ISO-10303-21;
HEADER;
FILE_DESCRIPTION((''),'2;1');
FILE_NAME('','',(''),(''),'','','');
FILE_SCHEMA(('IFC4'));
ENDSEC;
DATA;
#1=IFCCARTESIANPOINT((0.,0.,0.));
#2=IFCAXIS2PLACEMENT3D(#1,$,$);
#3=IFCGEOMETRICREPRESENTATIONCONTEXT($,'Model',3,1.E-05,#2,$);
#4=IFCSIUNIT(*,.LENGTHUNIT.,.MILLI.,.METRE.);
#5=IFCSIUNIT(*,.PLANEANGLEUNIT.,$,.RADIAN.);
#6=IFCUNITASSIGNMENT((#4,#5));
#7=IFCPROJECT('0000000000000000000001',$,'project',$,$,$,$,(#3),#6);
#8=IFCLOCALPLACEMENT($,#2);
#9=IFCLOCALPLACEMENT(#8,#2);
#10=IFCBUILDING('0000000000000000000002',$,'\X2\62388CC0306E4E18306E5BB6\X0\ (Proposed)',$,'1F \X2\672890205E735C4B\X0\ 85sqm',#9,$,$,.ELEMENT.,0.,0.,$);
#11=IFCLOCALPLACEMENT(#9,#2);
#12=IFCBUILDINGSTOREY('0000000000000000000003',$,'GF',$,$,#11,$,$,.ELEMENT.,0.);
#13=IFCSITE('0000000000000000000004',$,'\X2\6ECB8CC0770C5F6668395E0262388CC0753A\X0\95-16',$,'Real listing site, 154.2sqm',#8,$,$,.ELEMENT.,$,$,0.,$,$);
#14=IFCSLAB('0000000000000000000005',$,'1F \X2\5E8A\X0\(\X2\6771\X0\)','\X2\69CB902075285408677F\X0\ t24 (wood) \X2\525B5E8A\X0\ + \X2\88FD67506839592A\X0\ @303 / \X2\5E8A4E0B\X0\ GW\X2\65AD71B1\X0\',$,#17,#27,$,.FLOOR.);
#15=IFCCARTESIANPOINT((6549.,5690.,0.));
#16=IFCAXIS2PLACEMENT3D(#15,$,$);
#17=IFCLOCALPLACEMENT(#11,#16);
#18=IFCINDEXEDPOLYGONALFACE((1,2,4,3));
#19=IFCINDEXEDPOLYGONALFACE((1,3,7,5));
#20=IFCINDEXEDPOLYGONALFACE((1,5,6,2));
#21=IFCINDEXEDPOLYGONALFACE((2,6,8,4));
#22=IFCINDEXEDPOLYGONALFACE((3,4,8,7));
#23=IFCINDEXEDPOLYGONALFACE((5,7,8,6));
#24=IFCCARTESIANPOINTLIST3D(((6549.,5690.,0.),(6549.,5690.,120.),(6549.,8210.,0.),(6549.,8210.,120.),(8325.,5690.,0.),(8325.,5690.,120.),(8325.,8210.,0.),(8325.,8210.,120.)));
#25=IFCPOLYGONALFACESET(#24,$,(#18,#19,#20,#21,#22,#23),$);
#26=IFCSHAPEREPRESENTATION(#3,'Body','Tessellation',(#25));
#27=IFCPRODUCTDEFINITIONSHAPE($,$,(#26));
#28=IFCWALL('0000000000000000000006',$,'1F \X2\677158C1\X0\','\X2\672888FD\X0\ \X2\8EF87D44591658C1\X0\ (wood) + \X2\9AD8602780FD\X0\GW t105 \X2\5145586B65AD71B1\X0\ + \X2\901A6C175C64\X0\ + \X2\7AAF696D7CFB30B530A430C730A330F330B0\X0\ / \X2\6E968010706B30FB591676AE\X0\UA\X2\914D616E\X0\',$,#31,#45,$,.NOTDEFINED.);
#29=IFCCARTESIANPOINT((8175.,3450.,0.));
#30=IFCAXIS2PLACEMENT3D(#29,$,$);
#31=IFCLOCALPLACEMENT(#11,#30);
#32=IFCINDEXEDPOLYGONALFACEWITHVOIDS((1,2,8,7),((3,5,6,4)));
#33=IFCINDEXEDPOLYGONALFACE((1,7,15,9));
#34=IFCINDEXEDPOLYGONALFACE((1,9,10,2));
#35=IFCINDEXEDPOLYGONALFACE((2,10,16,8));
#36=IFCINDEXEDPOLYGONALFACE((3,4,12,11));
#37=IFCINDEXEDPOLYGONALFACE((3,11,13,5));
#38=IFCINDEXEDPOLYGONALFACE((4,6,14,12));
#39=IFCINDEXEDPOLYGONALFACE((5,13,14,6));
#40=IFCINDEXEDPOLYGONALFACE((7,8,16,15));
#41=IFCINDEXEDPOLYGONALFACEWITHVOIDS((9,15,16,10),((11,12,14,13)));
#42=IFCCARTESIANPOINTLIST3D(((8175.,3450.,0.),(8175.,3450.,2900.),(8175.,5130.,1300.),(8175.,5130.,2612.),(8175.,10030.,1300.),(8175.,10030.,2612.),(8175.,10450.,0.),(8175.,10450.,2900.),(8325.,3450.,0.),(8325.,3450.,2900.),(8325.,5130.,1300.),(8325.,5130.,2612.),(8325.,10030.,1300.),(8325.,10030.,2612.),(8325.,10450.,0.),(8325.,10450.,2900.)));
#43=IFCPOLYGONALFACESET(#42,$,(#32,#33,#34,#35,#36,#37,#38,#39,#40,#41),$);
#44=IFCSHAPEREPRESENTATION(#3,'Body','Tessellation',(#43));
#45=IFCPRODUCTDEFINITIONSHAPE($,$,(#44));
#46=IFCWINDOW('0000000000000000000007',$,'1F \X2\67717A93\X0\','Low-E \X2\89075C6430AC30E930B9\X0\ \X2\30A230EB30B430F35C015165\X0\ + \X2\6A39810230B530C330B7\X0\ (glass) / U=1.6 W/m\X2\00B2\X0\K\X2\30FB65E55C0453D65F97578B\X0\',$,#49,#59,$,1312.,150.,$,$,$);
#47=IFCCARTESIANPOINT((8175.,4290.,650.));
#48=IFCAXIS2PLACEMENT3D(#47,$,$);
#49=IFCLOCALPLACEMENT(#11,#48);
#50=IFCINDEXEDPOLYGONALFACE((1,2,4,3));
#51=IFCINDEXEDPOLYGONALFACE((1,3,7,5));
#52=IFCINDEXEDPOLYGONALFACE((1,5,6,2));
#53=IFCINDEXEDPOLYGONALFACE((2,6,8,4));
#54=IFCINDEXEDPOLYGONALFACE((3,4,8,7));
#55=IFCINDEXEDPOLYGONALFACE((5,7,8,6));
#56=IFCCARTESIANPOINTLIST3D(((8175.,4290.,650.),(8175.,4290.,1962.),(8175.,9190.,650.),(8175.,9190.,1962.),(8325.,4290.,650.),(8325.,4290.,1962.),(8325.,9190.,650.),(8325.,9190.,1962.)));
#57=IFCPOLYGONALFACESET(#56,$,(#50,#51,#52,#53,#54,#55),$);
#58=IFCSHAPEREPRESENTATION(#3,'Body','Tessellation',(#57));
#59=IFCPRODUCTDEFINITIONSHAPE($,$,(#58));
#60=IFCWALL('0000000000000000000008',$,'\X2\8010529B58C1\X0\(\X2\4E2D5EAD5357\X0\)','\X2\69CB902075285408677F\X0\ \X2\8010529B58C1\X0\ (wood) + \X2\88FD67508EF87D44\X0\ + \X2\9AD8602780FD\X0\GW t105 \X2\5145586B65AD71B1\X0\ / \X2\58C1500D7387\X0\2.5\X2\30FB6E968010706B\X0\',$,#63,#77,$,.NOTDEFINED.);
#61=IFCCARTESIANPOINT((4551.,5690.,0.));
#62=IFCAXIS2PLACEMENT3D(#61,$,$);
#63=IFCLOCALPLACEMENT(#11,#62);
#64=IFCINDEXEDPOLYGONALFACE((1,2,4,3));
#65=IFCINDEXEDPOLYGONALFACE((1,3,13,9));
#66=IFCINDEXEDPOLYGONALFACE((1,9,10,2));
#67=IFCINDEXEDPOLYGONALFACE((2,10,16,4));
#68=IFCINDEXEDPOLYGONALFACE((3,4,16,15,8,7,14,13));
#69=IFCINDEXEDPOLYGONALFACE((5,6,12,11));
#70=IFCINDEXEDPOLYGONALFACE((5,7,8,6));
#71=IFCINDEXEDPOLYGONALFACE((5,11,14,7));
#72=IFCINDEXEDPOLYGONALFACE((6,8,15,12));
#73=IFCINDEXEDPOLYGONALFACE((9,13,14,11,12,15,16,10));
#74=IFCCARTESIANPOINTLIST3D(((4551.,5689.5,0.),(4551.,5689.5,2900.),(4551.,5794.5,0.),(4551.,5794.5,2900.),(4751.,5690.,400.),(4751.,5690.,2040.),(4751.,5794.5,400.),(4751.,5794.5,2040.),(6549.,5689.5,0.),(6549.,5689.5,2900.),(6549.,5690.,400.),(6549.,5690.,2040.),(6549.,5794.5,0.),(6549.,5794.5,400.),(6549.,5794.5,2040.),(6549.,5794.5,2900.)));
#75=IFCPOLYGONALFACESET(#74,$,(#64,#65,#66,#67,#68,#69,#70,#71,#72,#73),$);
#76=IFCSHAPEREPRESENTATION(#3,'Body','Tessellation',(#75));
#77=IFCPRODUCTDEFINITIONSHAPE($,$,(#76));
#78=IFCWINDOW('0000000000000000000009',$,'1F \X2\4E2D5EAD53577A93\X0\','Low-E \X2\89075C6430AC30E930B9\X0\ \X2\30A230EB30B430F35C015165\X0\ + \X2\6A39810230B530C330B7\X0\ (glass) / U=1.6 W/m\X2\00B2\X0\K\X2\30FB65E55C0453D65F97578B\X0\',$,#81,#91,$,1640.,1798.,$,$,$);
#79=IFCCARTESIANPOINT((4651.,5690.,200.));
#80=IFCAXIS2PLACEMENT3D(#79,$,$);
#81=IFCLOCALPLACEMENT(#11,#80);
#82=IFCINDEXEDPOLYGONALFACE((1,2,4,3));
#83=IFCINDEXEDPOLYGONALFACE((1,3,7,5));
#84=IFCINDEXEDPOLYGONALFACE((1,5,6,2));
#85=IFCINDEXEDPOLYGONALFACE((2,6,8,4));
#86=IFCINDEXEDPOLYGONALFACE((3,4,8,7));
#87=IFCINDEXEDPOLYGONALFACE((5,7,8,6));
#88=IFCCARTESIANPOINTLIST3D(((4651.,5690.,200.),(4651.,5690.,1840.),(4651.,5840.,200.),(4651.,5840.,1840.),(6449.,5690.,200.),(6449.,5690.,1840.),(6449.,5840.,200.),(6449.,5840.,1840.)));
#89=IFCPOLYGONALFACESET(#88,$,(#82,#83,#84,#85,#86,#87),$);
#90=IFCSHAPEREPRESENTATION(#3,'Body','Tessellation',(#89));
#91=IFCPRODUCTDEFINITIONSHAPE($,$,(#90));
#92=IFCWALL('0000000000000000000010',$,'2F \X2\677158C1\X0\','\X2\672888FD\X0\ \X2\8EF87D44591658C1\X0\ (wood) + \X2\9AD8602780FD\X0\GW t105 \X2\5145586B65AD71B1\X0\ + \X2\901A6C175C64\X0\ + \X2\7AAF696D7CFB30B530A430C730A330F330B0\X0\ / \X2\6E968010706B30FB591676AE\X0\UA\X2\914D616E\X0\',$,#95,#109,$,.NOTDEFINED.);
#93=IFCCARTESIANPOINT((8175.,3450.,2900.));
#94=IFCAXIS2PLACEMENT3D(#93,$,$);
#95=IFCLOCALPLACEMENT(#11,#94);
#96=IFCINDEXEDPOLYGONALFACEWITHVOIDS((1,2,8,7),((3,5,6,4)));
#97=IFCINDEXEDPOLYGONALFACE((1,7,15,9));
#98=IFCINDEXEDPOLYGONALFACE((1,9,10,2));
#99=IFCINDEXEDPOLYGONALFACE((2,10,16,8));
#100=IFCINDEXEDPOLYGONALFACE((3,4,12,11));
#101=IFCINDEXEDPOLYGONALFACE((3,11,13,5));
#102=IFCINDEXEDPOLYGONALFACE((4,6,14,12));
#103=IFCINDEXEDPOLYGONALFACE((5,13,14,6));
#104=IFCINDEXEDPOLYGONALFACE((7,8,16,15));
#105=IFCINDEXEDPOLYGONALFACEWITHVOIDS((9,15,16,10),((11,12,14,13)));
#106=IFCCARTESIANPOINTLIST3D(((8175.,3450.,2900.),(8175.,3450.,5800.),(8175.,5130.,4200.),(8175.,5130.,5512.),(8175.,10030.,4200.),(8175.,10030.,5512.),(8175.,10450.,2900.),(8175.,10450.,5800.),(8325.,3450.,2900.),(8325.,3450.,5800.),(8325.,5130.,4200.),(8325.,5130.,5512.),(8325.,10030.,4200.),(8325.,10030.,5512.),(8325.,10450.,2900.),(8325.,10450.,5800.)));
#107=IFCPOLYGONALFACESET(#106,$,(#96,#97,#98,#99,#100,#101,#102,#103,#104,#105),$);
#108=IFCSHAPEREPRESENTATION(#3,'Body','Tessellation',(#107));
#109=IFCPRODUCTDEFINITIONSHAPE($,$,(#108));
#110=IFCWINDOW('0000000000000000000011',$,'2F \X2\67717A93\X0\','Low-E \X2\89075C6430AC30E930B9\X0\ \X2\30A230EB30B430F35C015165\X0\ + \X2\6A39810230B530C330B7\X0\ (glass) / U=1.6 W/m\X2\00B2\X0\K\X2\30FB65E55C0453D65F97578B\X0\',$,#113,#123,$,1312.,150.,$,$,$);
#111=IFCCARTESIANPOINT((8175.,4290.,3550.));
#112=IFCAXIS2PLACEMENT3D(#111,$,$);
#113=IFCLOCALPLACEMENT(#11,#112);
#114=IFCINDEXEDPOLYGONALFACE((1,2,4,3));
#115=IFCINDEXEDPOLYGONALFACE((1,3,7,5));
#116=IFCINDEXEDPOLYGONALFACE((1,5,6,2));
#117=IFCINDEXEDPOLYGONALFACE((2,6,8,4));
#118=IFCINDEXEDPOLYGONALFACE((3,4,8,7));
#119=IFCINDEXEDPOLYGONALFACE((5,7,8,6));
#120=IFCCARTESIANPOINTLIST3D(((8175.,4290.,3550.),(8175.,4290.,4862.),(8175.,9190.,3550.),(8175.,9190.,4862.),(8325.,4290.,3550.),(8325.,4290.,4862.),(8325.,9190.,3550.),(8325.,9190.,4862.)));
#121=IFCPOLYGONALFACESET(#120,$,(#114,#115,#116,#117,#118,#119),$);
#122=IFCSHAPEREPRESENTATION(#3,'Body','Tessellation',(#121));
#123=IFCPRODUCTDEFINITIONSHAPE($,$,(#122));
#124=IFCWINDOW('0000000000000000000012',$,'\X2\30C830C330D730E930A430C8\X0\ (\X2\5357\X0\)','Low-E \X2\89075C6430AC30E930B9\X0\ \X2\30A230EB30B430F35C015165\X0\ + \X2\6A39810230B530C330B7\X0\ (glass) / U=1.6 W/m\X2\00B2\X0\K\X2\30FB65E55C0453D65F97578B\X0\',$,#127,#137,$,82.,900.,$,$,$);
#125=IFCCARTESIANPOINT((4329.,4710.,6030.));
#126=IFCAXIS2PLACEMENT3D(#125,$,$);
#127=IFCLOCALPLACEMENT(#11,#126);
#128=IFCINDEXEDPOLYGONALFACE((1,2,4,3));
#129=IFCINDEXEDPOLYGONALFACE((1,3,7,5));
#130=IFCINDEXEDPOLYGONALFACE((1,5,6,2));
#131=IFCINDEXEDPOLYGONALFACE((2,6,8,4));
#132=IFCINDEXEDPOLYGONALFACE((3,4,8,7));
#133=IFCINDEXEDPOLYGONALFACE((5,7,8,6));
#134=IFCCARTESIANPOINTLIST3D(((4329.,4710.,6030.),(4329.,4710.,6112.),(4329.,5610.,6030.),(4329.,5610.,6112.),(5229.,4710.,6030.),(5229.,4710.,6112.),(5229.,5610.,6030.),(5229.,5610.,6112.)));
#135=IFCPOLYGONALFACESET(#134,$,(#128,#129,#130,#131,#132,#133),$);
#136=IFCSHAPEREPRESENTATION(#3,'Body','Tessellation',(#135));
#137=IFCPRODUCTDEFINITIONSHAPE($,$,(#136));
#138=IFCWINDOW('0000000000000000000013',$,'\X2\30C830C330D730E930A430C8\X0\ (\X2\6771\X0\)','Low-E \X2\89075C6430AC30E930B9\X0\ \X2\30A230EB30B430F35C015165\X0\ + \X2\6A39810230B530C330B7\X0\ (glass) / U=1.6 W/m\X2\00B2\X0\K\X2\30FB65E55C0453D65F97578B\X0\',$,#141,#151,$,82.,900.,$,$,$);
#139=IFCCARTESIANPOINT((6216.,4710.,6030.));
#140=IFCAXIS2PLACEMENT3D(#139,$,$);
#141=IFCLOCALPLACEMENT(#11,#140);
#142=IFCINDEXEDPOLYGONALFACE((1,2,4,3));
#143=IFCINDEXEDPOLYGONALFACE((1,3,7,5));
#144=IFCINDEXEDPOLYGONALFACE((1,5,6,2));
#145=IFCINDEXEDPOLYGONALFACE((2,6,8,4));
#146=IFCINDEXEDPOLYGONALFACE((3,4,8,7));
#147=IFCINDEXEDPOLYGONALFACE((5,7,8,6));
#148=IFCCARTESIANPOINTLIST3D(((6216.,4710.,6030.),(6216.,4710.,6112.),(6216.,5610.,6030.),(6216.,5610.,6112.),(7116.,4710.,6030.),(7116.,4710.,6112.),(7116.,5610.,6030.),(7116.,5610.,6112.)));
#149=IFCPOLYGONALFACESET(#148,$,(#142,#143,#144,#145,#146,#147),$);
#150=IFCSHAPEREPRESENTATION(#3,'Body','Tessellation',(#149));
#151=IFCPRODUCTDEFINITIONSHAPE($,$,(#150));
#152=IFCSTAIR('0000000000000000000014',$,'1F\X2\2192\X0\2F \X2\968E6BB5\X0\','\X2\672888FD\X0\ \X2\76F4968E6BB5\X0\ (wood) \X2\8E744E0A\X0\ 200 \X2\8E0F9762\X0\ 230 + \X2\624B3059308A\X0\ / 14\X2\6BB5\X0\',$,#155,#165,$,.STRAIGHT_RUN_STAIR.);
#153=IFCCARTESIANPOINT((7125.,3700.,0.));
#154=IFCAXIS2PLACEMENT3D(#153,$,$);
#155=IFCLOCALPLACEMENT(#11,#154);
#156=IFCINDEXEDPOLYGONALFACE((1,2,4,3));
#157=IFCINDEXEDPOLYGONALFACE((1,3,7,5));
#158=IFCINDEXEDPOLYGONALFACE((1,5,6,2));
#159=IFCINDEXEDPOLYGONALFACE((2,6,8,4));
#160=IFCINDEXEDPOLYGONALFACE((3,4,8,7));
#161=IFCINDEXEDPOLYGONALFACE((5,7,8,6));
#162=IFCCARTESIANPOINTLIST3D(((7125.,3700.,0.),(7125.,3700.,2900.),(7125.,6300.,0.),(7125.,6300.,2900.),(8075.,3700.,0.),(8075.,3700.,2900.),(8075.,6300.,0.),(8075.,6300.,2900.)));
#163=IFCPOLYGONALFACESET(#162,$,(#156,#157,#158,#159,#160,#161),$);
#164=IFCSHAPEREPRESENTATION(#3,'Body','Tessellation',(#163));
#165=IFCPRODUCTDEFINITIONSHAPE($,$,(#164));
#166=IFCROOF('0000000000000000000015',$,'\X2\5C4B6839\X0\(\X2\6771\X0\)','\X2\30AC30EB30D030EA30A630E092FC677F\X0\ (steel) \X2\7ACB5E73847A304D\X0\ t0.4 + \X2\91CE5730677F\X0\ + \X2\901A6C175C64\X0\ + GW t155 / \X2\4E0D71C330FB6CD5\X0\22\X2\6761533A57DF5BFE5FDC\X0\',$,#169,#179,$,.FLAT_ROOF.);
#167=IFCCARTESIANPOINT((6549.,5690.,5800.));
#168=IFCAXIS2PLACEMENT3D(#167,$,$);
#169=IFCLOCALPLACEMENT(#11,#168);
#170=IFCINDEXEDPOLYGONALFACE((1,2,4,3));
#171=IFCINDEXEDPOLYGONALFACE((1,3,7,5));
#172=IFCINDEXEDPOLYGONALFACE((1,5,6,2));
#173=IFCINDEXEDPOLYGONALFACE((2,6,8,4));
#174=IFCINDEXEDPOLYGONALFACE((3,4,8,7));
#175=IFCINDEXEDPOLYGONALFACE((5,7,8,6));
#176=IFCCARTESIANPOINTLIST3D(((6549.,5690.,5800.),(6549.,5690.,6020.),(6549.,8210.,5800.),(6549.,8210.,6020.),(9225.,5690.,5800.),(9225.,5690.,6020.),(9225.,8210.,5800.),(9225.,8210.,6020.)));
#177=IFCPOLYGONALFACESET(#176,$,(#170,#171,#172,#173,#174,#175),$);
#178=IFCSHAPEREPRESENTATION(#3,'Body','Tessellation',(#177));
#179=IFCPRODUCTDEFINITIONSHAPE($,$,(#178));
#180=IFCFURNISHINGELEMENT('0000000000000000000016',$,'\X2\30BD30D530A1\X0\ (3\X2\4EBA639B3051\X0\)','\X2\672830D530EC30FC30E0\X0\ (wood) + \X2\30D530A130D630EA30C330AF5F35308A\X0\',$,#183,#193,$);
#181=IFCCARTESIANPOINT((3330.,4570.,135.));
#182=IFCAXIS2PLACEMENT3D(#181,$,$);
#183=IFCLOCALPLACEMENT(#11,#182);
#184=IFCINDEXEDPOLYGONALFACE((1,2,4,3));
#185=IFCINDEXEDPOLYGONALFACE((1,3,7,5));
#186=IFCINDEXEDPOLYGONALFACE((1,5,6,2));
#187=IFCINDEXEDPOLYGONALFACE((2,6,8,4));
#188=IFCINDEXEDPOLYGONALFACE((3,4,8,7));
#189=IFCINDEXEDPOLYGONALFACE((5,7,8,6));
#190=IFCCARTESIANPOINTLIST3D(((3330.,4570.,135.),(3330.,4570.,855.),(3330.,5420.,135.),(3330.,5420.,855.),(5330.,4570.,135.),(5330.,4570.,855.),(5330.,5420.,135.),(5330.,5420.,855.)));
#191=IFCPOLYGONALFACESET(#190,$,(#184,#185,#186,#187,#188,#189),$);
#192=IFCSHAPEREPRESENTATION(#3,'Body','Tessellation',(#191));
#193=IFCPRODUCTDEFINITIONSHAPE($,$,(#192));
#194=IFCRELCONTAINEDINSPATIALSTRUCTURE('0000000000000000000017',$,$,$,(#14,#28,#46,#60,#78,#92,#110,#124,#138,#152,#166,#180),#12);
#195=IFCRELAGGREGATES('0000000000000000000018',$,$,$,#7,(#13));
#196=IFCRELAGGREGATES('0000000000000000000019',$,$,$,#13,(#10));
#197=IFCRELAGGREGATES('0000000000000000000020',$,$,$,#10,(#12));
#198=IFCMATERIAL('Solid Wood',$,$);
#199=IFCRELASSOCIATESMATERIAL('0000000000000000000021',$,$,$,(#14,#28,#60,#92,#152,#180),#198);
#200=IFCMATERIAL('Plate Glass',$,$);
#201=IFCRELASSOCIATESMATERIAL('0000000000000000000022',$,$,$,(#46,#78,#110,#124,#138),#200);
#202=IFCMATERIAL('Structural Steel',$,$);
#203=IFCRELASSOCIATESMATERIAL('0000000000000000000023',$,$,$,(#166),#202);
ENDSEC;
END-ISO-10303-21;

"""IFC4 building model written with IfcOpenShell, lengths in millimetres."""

from ifc_helpers import new_model, si_unit, frame, frame_2d, origin, place, context, project, spatial, rectangle, extrude, material, element, fill, save


model = new_model("IFC4")

# Units and contexts
model_context = context("Model", 3, precision=1e-05, world=origin())
ifc_project = project(units=[si_unit("LENGTHUNIT", "METRE", prefix="MILLI"), si_unit("PLANEANGLEUNIT", "RADIAN")], contexts=[model_context])

# Site, building, storey
site_placement = place(None, origin())
site = spatial("IfcSite", under=ifc_project, at=site_placement, Name="滋賀県彦根市戸賀町95-16", ObjectType="Real listing site, 154.2sqm", CompositionType="ELEMENT", RefElevation=0.0)
building_placement = place(site_placement, origin())
building = spatial("IfcBuilding", under=site, at=building_placement, Name="戸賀の丘の家 (Proposed)", ObjectType="1F 木造平屋 85sqm", CompositionType="ELEMENT", ElevationOfRefHeight=0.0, ElevationOfTerrain=0.0)
storey_placement = place(building_placement, origin())
storey = spatial("IfcBuildingStorey", under=building, at=storey_placement, Name="GF", CompositionType="ELEMENT", Elevation=0.0)

# Slab
ifc_material_1 = material(Name="Solid Wood")
slab_placement = place(storey_placement, frame((6549.0, 5690.0, 0.0)))
element("IfcSlab", 1, at=slab_placement, inside=storey, material=ifc_material_1, Name="1F 床(東)", Description="構造用合板 t24 (wood) 剛床 + 製材根太 @303 / 床下 GW断熱", PredefinedType="FLOOR", context=model_context, shape_type="SweptSolid", body=[
    extrude(rectangle(XDim=1776.0, YDim=2520.0, at=frame_2d((888.0, 1260.0))), frame((6549.0, 5690.0, 0.0)), (0.0, 0.0, 1.0), 120.0),
])

# Walls, openings, windows
wall_1_placement = place(storey_placement, frame((8175.0, 3450.0, 0.0)))
wall_1 = element("IfcWall", 2, at=wall_1_placement, inside=storey, material=ifc_material_1, Name="1F 東壁", Description="木製 軸組外壁 (wood) + 高性能GW t105 充填断熱 + 通気層 + 窯業系サイディング / 準耐火・外皮UA配慮", PredefinedType="NOTDEFINED", context=model_context, shape_type="SweptSolid", body=[
    extrude(rectangle(XDim=150.0, YDim=7000.0, at=frame_2d((75.0, 3500.0))), frame((8175.0, 3450.0, 0.0)), (0.0, 0.0, 1.0), 2900.0),
])
opening_1_placement = place(storey_placement, frame((8175.0, 4290.0, 650.0)))
opening_1 = element("IfcOpeningElement", 3, at=opening_1_placement, cuts=wall_1, PredefinedType="NOTDEFINED", context=model_context, shape_type="SweptSolid", body=[
    extrude(rectangle(XDim=150.0, YDim=4900.0, at=frame_2d((75.0, 2450.0))), frame((8175.0, 4290.0, 650.0)), (0.0, 0.0, 1.0), 1312.0),
])
ifc_material_2 = material(Name="Plate Glass")
window_1_placement = place(storey_placement, frame((8175.0, 4290.0, 650.0)))
window_1 = element("IfcWindow", 4, at=window_1_placement, inside=storey, material=ifc_material_2, Name="1F 東窓", Description="Low-E 複層ガラス アルゴン封入 + 樹脂サッシ (glass) / U=1.6 W/m²K・日射取得型", OverallHeight=1312.0, OverallWidth=150.0, context=model_context, shape_type="SweptSolid", body=[
    extrude(rectangle(XDim=150.0, YDim=4900.0, at=frame_2d((75.0, 2450.0))), frame((8175.0, 4290.0, 650.0)), (0.0, 0.0, 1.0), 1312.0),
])
fill(opening_1, window_1)
wall_2_placement = place(storey_placement, frame((4551.0, 5690.0, 0.0)))
wall_2 = element("IfcWall", 5, at=wall_2_placement, inside=storey, material=ifc_material_1, Name="耐力壁(中庭南)", Description="構造用合板 耐力壁 (wood) + 製材軸組 + 高性能GW t105 充填断熱 / 壁倍率2.5・準耐火", PredefinedType="NOTDEFINED", context=model_context, shape_type="SweptSolid", body=[
    extrude(rectangle(XDim=1998.0, YDim=105.0, at=frame_2d((999.0, 52.0))), frame((4551.0, 5690.0, 0.0)), (0.0, 0.0, 1.0), 2900.0),
])
opening_2_placement = place(storey_placement, frame((4651.0, 5690.0, 200.0)))
opening_2 = element("IfcOpeningElement", 6, at=opening_2_placement, cuts=wall_2, PredefinedType="NOTDEFINED", context=model_context, shape_type="SweptSolid", body=[
    extrude(rectangle(XDim=1798.0, YDim=150.0, at=frame_2d((899.0, 75.0))), frame((4651.0, 5690.0, 200.0)), (0.0, 0.0, 1.0), 1640.0),
])
window_2_placement = place(storey_placement, frame((4651.0, 5690.0, 200.0)))
window_2 = element("IfcWindow", 7, at=window_2_placement, inside=storey, material=ifc_material_2, Name="1F 中庭南窓", Description="Low-E 複層ガラス アルゴン封入 + 樹脂サッシ (glass) / U=1.6 W/m²K・日射取得型", OverallHeight=1640.0, OverallWidth=1798.0, context=model_context, shape_type="SweptSolid", body=[
    extrude(rectangle(XDim=1798.0, YDim=150.0, at=frame_2d((899.0, 75.0))), frame((4651.0, 5690.0, 200.0)), (0.0, 0.0, 1.0), 1640.0),
])
fill(opening_2, window_2)

# Wall, opening, window
wall_3_placement = place(storey_placement, frame((8175.0, 3450.0, 2900.0)))
wall_3 = element("IfcWall", 8, at=wall_3_placement, inside=storey, material=ifc_material_1, Name="2F 東壁", Description="木製 軸組外壁 (wood) + 高性能GW t105 充填断熱 + 通気層 + 窯業系サイディング / 準耐火・外皮UA配慮", PredefinedType="NOTDEFINED", context=model_context, shape_type="SweptSolid", body=[
    extrude(rectangle(XDim=150.0, YDim=7000.0, at=frame_2d((75.0, 3500.0))), frame((8175.0, 3450.0, 2900.0)), (0.0, 0.0, 1.0), 2900.0),
])
opening_3_placement = place(storey_placement, frame((8175.0, 4290.0, 3550.0)))
opening_3 = element("IfcOpeningElement", 9, at=opening_3_placement, cuts=wall_3, PredefinedType="NOTDEFINED", context=model_context, shape_type="SweptSolid", body=[
    extrude(rectangle(XDim=150.0, YDim=4900.0, at=frame_2d((75.0, 2450.0))), frame((8175.0, 4290.0, 3550.0)), (0.0, 0.0, 1.0), 1312.0),
])
window_3_placement = place(storey_placement, frame((8175.0, 4290.0, 3550.0)))
window_3 = element("IfcWindow", 10, at=window_3_placement, inside=storey, material=ifc_material_2, Name="2F 東窓", Description="Low-E 複層ガラス アルゴン封入 + 樹脂サッシ (glass) / U=1.6 W/m²K・日射取得型", OverallHeight=1312.0, OverallWidth=150.0, context=model_context, shape_type="SweptSolid", body=[
    extrude(rectangle(XDim=150.0, YDim=4900.0, at=frame_2d((75.0, 2450.0))), frame((8175.0, 4290.0, 3550.0)), (0.0, 0.0, 1.0), 1312.0),
])
fill(opening_3, window_3)

# Windows
window_4_placement = place(storey_placement, frame((4329.0, 4710.0, 6030.0)))
element("IfcWindow", 11, at=window_4_placement, inside=storey, material=ifc_material_2, Name="トップライト (南)", Description="Low-E 複層ガラス アルゴン封入 + 樹脂サッシ (glass) / U=1.6 W/m²K・日射取得型", OverallHeight=82.0, OverallWidth=900.0, context=model_context, shape_type="SweptSolid", body=[
    extrude(rectangle(XDim=900.0, YDim=900.0, at=frame_2d((450.0, 450.0))), frame((4329.0, 4710.0, 6030.0)), (0.0, 0.0, 1.0), 82.0),
])
window_5_placement = place(storey_placement, frame((6216.0, 4710.0, 6030.0)))
element("IfcWindow", 12, at=window_5_placement, inside=storey, material=ifc_material_2, Name="トップライト (東)", Description="Low-E 複層ガラス アルゴン封入 + 樹脂サッシ (glass) / U=1.6 W/m²K・日射取得型", OverallHeight=82.0, OverallWidth=900.0, context=model_context, shape_type="SweptSolid", body=[
    extrude(rectangle(XDim=900.0, YDim=900.0, at=frame_2d((450.0, 450.0))), frame((6216.0, 4710.0, 6030.0)), (0.0, 0.0, 1.0), 82.0),
])

# Stair
stair_placement = place(storey_placement, frame((7125.0, 3700.0, 0.0)))
element("IfcStair", 13, at=stair_placement, inside=storey, material=ifc_material_1, Name="1F→2F 階段", Description="木製 直階段 (wood) 蹴上 200 踏面 230 + 手すり / 14段", PredefinedType="STRAIGHT_RUN_STAIR", context=model_context, shape_type="SweptSolid", body=[
    extrude(rectangle(XDim=950.0, YDim=2600.0, at=frame_2d((475.0, 1300.0))), frame((7125.0, 3700.0, 0.0)), (0.0, 0.0, 1.0), 2900.0),
])

# Roof
ifc_material_3 = material(Name="Structural Steel")
roof_placement = place(storey_placement, frame((6549.0, 5690.0, 5800.0)))
element("IfcRoof", 14, at=roof_placement, inside=storey, material=ifc_material_3, Name="屋根(東)", Description="ガルバリウム鋼板 (steel) 立平葺き t0.4 + 野地板 + 通気層 + GW t155 / 不燃・法22条区域対応", PredefinedType="FLAT_ROOF", context=model_context, shape_type="SweptSolid", body=[
    extrude(rectangle(XDim=2676.0, YDim=2520.0, at=frame_2d((1338.0, 1260.0))), frame((6549.0, 5690.0, 5800.0)), (0.0, 0.0, 1.0), 220.0),
])

# Furnishing element
furnishing_1_placement = place(storey_placement, frame((3330.0, 4570.0, 135.0)))
element("IfcFurnishingElement", 15, at=furnishing_1_placement, inside=storey, material=ifc_material_1, Name="ソファ (3人掛け)", Description="木フレーム (wood) + ファブリック張り", context=model_context, shape_type="SweptSolid", body=[
    extrude(rectangle(XDim=2000.0, YDim=850.0, at=frame_2d((1000.0, 425.0))), frame((3330.0, 4570.0, 135.0)), (0.0, 0.0, 1.0), 720.0),
])

save(model, "model.ifc")
